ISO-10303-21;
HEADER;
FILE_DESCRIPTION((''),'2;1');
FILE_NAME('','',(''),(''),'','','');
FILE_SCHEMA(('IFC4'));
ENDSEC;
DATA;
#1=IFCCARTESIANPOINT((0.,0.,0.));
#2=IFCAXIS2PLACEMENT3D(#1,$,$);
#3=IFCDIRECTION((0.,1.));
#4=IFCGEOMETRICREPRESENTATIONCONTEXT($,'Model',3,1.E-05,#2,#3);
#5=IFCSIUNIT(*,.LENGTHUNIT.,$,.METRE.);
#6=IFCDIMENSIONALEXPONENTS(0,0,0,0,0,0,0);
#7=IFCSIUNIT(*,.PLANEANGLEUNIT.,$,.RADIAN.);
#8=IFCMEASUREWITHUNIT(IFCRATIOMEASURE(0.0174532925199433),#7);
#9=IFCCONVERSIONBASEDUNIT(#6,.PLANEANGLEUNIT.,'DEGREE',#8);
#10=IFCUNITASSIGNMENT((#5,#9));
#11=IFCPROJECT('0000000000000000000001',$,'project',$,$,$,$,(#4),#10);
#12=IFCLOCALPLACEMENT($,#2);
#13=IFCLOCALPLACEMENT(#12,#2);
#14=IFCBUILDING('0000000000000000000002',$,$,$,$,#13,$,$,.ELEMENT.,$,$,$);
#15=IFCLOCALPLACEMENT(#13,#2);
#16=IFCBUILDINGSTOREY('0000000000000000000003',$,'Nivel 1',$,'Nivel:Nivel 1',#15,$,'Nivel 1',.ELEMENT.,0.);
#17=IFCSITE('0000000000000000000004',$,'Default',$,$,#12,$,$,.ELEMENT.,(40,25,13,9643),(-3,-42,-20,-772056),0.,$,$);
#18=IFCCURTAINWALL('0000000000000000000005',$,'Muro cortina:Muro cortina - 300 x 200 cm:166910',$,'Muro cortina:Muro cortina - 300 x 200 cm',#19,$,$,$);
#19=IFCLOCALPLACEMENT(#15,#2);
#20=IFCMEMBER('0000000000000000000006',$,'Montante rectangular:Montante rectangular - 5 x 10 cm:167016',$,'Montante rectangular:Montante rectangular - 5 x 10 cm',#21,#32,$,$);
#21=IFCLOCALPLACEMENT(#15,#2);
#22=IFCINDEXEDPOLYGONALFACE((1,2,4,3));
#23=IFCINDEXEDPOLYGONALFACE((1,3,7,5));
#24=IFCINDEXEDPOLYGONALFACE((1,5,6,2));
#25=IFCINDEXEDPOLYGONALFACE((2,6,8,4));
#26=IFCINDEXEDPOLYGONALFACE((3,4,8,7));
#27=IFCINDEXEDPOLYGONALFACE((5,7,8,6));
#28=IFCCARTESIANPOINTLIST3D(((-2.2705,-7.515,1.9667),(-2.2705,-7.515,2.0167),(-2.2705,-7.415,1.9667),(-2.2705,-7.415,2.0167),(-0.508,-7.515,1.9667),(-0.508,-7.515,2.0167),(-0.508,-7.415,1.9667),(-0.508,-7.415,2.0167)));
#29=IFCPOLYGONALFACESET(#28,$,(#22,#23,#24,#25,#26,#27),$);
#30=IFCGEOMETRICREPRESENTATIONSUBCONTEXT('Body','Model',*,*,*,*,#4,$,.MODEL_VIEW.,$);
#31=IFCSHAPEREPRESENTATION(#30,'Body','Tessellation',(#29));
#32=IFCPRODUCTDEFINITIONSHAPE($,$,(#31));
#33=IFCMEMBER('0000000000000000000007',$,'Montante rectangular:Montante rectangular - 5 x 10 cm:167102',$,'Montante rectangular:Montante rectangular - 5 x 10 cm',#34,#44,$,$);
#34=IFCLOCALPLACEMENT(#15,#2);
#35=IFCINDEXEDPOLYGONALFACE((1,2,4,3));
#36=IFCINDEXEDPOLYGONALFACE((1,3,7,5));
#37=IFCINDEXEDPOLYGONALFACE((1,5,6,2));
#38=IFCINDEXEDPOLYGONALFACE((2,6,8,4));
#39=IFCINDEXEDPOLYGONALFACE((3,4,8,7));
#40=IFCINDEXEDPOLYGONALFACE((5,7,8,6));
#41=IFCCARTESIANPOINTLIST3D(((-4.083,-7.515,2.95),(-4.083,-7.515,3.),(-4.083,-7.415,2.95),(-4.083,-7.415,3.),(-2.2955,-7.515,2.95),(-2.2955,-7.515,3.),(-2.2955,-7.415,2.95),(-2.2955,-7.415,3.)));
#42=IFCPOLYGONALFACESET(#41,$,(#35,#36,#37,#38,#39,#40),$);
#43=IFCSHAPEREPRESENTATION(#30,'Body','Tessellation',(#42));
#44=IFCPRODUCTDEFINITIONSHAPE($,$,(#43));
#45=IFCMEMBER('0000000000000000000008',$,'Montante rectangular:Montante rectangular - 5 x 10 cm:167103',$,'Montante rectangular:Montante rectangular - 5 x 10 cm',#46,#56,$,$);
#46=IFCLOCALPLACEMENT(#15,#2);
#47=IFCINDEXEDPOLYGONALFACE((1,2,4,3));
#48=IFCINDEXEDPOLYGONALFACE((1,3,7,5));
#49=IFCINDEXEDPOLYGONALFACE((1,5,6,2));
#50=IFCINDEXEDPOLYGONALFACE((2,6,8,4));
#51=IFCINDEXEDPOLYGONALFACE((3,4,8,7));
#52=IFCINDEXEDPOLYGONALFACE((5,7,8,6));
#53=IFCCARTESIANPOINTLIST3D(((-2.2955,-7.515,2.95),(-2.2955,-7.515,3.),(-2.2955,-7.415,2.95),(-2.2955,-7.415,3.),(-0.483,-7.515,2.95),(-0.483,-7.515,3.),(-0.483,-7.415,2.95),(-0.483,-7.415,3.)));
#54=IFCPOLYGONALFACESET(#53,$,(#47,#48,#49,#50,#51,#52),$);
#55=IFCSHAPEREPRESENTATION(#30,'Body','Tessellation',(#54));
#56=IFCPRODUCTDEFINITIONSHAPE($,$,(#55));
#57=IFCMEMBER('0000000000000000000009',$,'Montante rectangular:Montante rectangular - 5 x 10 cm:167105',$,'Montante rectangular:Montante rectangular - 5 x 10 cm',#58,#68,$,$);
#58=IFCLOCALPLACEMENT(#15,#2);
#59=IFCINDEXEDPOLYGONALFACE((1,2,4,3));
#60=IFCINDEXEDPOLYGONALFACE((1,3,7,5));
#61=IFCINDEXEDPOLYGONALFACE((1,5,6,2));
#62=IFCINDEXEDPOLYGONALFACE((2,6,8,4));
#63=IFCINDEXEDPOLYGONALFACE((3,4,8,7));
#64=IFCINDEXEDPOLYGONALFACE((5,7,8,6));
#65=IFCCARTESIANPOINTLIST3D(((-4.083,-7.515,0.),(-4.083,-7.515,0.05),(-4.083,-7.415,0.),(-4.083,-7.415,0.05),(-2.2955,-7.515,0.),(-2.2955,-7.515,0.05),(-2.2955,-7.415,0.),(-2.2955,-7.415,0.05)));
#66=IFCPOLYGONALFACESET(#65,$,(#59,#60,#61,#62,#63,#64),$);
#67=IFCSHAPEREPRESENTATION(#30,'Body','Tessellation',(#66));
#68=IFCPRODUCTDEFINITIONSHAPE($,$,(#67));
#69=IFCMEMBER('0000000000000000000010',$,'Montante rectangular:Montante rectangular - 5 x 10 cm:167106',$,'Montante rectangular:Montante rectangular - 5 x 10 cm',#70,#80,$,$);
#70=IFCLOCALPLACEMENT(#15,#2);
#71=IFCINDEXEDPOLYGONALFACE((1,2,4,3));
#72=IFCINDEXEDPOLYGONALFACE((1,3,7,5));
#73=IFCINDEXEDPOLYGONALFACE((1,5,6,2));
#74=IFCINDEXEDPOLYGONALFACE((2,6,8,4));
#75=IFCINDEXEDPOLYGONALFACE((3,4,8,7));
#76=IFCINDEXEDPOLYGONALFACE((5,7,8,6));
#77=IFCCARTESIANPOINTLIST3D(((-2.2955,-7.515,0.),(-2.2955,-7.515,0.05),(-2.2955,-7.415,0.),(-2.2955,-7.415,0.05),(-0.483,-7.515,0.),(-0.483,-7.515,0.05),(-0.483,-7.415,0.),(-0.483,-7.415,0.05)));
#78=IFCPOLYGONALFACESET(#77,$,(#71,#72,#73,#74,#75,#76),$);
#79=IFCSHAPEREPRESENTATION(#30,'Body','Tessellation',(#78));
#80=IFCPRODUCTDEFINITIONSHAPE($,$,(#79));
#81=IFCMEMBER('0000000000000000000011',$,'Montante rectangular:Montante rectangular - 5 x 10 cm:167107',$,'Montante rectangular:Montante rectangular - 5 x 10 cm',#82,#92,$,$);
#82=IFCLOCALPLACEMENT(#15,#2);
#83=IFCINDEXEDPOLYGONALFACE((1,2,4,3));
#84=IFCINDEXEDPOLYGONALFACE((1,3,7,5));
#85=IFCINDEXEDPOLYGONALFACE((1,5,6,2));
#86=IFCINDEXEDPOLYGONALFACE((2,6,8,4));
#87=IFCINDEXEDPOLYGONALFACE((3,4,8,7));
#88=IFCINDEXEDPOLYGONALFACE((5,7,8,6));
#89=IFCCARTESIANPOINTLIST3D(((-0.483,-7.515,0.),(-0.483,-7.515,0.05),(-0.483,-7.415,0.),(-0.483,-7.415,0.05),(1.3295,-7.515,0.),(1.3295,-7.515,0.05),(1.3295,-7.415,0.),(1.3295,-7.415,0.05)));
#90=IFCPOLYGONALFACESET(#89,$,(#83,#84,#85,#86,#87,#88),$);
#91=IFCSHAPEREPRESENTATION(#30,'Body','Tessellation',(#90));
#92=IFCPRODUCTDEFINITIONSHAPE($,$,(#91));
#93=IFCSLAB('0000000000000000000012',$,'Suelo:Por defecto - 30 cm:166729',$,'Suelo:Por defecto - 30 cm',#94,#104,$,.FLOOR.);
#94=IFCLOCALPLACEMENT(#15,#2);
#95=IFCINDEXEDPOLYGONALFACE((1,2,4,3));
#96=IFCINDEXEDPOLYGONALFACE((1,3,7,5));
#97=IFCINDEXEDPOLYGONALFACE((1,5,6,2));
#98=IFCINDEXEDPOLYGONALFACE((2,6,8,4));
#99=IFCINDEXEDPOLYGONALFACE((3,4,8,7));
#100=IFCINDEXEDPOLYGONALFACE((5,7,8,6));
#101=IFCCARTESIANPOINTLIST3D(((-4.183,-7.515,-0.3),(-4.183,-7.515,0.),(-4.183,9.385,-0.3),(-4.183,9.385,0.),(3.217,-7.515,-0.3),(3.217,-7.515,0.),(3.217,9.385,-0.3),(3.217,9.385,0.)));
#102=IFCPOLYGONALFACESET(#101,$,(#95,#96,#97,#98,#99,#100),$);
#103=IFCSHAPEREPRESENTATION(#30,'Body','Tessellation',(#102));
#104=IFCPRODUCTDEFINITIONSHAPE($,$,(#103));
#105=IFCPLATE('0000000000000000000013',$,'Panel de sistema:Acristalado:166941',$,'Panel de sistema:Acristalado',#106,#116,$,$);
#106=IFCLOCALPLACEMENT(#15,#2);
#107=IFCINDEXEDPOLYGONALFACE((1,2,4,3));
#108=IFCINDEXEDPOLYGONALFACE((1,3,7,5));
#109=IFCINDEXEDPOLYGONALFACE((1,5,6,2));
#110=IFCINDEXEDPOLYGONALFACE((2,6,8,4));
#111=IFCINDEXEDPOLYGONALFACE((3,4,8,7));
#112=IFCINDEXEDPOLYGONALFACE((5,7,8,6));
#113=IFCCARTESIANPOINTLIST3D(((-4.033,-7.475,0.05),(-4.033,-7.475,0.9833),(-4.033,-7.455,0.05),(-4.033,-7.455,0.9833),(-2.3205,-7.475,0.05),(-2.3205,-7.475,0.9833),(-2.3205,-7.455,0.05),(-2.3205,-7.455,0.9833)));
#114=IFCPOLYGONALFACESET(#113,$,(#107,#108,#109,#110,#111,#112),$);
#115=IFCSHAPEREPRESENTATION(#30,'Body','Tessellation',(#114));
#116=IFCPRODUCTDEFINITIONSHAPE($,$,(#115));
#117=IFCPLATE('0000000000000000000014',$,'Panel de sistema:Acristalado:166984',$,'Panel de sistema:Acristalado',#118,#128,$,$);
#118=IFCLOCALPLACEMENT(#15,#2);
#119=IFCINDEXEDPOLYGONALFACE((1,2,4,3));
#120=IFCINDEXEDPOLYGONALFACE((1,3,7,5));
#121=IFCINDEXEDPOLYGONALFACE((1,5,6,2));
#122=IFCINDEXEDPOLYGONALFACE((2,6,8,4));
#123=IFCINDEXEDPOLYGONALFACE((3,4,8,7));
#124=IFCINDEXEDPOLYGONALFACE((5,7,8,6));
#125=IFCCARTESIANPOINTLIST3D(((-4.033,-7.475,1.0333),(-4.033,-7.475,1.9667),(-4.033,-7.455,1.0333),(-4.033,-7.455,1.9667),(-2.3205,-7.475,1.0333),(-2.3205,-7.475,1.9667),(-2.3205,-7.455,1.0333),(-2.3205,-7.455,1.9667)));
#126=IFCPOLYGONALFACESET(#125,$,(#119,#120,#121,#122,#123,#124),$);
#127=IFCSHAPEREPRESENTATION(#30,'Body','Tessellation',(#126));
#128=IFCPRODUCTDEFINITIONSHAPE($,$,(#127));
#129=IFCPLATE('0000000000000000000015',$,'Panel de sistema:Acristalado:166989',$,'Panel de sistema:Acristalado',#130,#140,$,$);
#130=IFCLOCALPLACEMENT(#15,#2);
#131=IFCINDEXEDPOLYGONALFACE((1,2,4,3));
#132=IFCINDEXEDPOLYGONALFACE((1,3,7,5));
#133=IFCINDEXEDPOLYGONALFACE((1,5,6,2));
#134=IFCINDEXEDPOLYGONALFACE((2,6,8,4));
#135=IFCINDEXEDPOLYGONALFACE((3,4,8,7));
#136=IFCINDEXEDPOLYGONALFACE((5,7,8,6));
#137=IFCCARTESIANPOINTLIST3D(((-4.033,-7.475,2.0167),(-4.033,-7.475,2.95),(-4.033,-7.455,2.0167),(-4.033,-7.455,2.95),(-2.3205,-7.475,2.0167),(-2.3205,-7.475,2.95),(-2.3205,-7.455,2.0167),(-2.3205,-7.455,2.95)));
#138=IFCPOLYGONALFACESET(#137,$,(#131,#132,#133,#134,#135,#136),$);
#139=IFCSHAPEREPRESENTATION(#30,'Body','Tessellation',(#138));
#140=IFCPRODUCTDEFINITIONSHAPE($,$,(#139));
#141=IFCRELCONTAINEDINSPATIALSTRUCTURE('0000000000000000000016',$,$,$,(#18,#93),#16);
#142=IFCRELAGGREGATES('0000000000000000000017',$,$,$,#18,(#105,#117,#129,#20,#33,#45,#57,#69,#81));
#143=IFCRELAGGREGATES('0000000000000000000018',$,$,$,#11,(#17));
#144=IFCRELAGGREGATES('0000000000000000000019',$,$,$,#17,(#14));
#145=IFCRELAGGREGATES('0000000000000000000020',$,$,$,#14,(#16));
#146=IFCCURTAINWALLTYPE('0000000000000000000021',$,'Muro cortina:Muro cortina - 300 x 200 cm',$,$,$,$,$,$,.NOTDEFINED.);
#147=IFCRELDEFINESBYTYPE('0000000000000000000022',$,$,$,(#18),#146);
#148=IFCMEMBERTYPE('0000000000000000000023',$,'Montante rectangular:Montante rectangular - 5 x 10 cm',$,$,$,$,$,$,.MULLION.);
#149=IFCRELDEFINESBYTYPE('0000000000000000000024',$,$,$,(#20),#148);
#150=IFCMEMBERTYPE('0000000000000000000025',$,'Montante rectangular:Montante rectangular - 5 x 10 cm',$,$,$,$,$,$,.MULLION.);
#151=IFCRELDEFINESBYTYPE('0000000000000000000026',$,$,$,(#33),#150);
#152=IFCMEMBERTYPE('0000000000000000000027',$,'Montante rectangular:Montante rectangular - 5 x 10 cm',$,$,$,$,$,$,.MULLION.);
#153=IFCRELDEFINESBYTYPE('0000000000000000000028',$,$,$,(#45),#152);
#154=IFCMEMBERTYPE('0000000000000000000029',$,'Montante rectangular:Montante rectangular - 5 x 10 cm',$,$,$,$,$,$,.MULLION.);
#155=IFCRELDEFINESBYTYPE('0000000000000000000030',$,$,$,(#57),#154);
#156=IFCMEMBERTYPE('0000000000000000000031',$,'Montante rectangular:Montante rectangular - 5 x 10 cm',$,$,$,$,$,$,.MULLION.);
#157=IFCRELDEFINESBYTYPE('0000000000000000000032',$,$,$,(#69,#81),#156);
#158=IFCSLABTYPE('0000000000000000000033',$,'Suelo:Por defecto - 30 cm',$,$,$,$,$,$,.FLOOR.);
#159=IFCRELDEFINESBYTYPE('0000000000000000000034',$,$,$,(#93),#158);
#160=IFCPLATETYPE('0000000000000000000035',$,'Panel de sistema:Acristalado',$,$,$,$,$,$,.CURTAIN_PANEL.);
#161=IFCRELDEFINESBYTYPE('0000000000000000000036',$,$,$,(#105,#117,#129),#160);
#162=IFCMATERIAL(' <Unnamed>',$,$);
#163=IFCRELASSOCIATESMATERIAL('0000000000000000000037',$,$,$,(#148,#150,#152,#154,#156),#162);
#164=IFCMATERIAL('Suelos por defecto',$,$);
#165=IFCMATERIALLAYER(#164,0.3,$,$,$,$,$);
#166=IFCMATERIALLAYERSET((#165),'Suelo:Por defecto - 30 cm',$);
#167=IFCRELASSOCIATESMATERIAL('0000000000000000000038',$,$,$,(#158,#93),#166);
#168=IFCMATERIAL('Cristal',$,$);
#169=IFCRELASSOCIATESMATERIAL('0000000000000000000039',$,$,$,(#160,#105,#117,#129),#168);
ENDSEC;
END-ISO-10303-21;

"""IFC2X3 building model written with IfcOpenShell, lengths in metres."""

from ifc_helpers import new_model, entity, si_unit, converted_unit, direction, frame, origin, origin_2d_with_axis, place, context, subcontext, project, spatial, rectangle, extrude, source, transform, mapped, material, layer, layer_set, layer_usage, type_object, type_shapes, element, aggregate, save


model = new_model("IFC2X3")

# Units and contexts
model_context = context("Model", 3, precision=1e-05, world=origin(), true_north=direction((0.0, 1.0)))
body_context = subcontext(model_context, "Body", "Model", "MODEL_VIEW")
ifc_project = project(units=[si_unit("LENGTHUNIT", "METRE"), converted_unit("PLANEANGLEUNIT", "DEGREE", entity("IfcRatioMeasure", 0.0174532925199433), si_unit("PLANEANGLEUNIT", "RADIAN"), dimensions=[0, 0, 0, 0, 0, 0, 0])], contexts=[model_context])

# Site, building, storey
site_placement = place(None, origin())
site = spatial("IfcSite", under=ifc_project, at=site_placement, Name="Default", CompositionType="ELEMENT", RefLatitude=(40, 25, 13, 9643), RefLongitude=(-3, -42, -20, -772056), RefElevation=0.0)
building_placement = place(site_placement, origin())
building = spatial("IfcBuilding", under=site, at=building_placement, CompositionType="ELEMENT")
storey_placement = place(building_placement, origin())
storey = spatial("IfcBuildingStorey", under=building, at=storey_placement, Name="Nivel 1", ObjectType="Nivel:Nivel 1", LongName="Nivel 1", CompositionType="ELEMENT", Elevation=0.0)

# Curtain wall, members
curtain_wall_type = type_object("IfcCurtainWallType", Name="Muro cortina:Muro cortina - 300 x 200 cm", PredefinedType="NOTDEFINED")
curtain_wall_placement = place(storey_placement, origin())
curtain_wall = element("IfcCurtainWall", 1, at=curtain_wall_placement, inside=storey, type_object=curtain_wall_type, Name="Muro cortina:Muro cortina - 300 x 200 cm:166910", ObjectType="Muro cortina:Muro cortina - 300 x 200 cm")
ifc_material_1 = material(Name=" <Unnamed>")
member_type_1 = type_object("IfcMemberType", Name="Montante rectangular:Montante rectangular - 5 x 10 cm", PredefinedType="MULLION", material=ifc_material_1)
shared_shape_1 = source(origin(), body_context, "Body", "SweptSolid", [
    extrude(rectangle(XDim=0.1, YDim=0.05, at=origin_2d_with_axis()), frame((0.0, 0.0, -1.7625), z_axis=(0.0, 0.0, 1.0), x_axis=(0.0, -1.0, 0.0)), (0.0, 0.0, 1.0), 1.7625),
])
type_shapes(member_type_1, [shared_shape_1])
member_1_placement = place(storey_placement, frame((-0.508, -7.465, 1.9917), z_axis=(1.0, 0.0, 0.0), x_axis=(0.0, 0.0, 1.0)))
member_1 = element("IfcMember", 2, at=member_1_placement, type_object=member_type_1, Name="Montante rectangular:Montante rectangular - 5 x 10 cm:167016", ObjectType="Montante rectangular:Montante rectangular - 5 x 10 cm", context=body_context, shape_type="MappedRepresentation", body=[
    mapped(shared_shape_1, transform((0.0, 0.0, 0.0), scale=1.0)),
])
member_type_2 = type_object("IfcMemberType", Name="Montante rectangular:Montante rectangular - 5 x 10 cm", PredefinedType="MULLION", material=ifc_material_1)
shared_shape_2 = source(origin(), body_context, "Body", "SweptSolid", [
    extrude(rectangle(XDim=0.1, YDim=0.05, at=origin_2d_with_axis()), frame((-0.025, 0.0, -1.7875), z_axis=(0.0, 0.0, 1.0), x_axis=(0.0, -1.0, 0.0)), (0.0, 0.0, 1.0), 1.7875),
])
type_shapes(member_type_2, [shared_shape_2])
member_2_placement = place(storey_placement, frame((-2.2955, -7.465, 3.0), z_axis=(1.0, 0.0, 0.0), x_axis=(0.0, 0.0, 1.0)))
member_2 = element("IfcMember", 3, at=member_2_placement, type_object=member_type_2, Name="Montante rectangular:Montante rectangular - 5 x 10 cm:167102", ObjectType="Montante rectangular:Montante rectangular - 5 x 10 cm", context=body_context, shape_type="MappedRepresentation", body=[
    mapped(shared_shape_2, transform((0.0, 0.0, 0.0), scale=1.0)),
])
member_type_3 = type_object("IfcMemberType", Name="Montante rectangular:Montante rectangular - 5 x 10 cm", PredefinedType="MULLION", material=ifc_material_1)
shared_shape_3 = source(origin(), body_context, "Body", "SweptSolid", [
    extrude(rectangle(XDim=0.1, YDim=0.05, at=origin_2d_with_axis()), frame((-0.025, 0.0, -1.8125), z_axis=(0.0, 0.0, 1.0), x_axis=(0.0, -1.0, 0.0)), (0.0, 0.0, 1.0), 1.8125),
])
type_shapes(member_type_3, [shared_shape_3])
member_3_placement = place(storey_placement, frame((-0.483, -7.465, 3.0), z_axis=(1.0, 0.0, 0.0), x_axis=(0.0, 0.0, 1.0)))
member_3 = element("IfcMember", 4, at=member_3_placement, type_object=member_type_3, Name="Montante rectangular:Montante rectangular - 5 x 10 cm:167103", ObjectType="Montante rectangular:Montante rectangular - 5 x 10 cm", context=body_context, shape_type="MappedRepresentation", body=[
    mapped(shared_shape_3, transform((0.0, 0.0, 0.0), scale=1.0)),
])
member_type_4 = type_object("IfcMemberType", Name="Montante rectangular:Montante rectangular - 5 x 10 cm", PredefinedType="MULLION", material=ifc_material_1)
shared_shape_4 = source(origin(), body_context, "Body", "SweptSolid", [
    extrude(rectangle(XDim=0.1, YDim=0.05, at=origin_2d_with_axis()), frame((-0.025, 0.0, -1.7875), z_axis=(0.0, 0.0, 1.0), x_axis=(0.0, -1.0, 0.0)), (0.0, 0.0, 1.0), 1.7875),
])
type_shapes(member_type_4, [shared_shape_4])
member_4_placement = place(storey_placement, frame((-4.083, -7.465, 0.0), z_axis=(-1.0, 0.0, 0.0), x_axis=(0.0, 0.0, -1.0)))
member_4 = element("IfcMember", 5, at=member_4_placement, type_object=member_type_4, Name="Montante rectangular:Montante rectangular - 5 x 10 cm:167105", ObjectType="Montante rectangular:Montante rectangular - 5 x 10 cm", context=body_context, shape_type="MappedRepresentation", body=[
    mapped(shared_shape_4, transform((0.0, 0.0, 0.0), scale=1.0)),
])
member_type_5 = type_object("IfcMemberType", Name="Montante rectangular:Montante rectangular - 5 x 10 cm", PredefinedType="MULLION", material=ifc_material_1)
shared_shape_5 = source(origin(), body_context, "Body", "SweptSolid", [
    extrude(rectangle(XDim=0.1, YDim=0.05, at=origin_2d_with_axis()), frame((-0.025, 0.0, -1.8125), z_axis=(0.0, 0.0, 1.0), x_axis=(0.0, -1.0, 0.0)), (0.0, 0.0, 1.0), 1.8125),
])
type_shapes(member_type_5, [shared_shape_5])
member_5_placement = place(storey_placement, frame((-2.2955, -7.465, 0.0), z_axis=(-1.0, 0.0, 0.0), x_axis=(0.0, 0.0, -1.0)))
member_5 = element("IfcMember", 6, at=member_5_placement, type_object=member_type_5, Name="Montante rectangular:Montante rectangular - 5 x 10 cm:167106", ObjectType="Montante rectangular:Montante rectangular - 5 x 10 cm", context=body_context, shape_type="MappedRepresentation", body=[
    mapped(shared_shape_5, transform((0.0, 0.0, 0.0), scale=1.0)),
])
member_6_placement = place(storey_placement, frame((-0.483, -7.465, 0.0), z_axis=(-1.0, 0.0, 0.0), x_axis=(0.0, 0.0, -1.0)))
member_6 = element("IfcMember", 7, at=member_6_placement, type_object=member_type_5, Name="Montante rectangular:Montante rectangular - 5 x 10 cm:167107", ObjectType="Montante rectangular:Montante rectangular - 5 x 10 cm", context=body_context, shape_type="MappedRepresentation", body=[
    mapped(shared_shape_5, transform((0.0, 0.0, 0.0), scale=1.0)),
])

# Slab
ifc_material_2 = material(Name="Suelos por defecto")
ifc_layer_1 = layer(ifc_material_2, 0.3)
ifc_layer_set_1 = layer_set([ifc_layer_1], Name="Suelo:Por defecto - 30 cm")
ifc_layer_usage_1 = layer_usage(ifc_layer_set_1, "AXIS3", "POSITIVE", 0.0)
slab_type = type_object("IfcSlabType", Name="Suelo:Por defecto - 30 cm", PredefinedType="FLOOR", material=ifc_layer_set_1)
slab_placement = place(storey_placement, origin())
element("IfcSlab", 8, at=slab_placement, inside=storey, type_object=slab_type, material=ifc_layer_usage_1, Name="Suelo:Por defecto - 30 cm:166729", ObjectType="Suelo:Por defecto - 30 cm", PredefinedType="FLOOR", context=body_context, shape_type="SweptSolid", body=[
    extrude(rectangle(XDim=16.9, YDim=7.4, at=origin_2d_with_axis()), frame((-0.483, 0.935, 0.0), z_axis=(0.0, 0.0, -1.0), x_axis=(0.0, 1.0, 0.0)), (0.0, 0.0, 1.0), 0.3),
])

# Plates
ifc_material_3 = material(Name="Cristal")
plate_type = type_object("IfcPlateType", Name="Panel de sistema:Acristalado", PredefinedType="CURTAIN_PANEL", material=ifc_material_3)
shared_shape_6 = source(origin(), body_context, "Body", "SweptSolid", [
    extrude(rectangle(XDim=0.02, YDim=1.7125, at=origin_2d_with_axis()), frame((0.0, 0.0, 0.0), z_axis=(0.0, 0.0, 1.0), x_axis=(0.0, 1.0, 0.0)), (0.0, 0.0, 1.0), 0.9333),
])
type_shapes(plate_type, [shared_shape_6])
plate_1_placement = place(curtain_wall_placement, frame((-3.1768, -7.465, 0.05)))
plate_1 = element("IfcPlate", 9, at=plate_1_placement, type_object=plate_type, material=ifc_material_3, Name="Panel de sistema:Acristalado:166941", ObjectType="Panel de sistema:Acristalado", context=body_context, shape_type="MappedRepresentation", body=[
    mapped(shared_shape_6, transform((0.0, 0.0, 0.0), scale=1.0)),
])
plate_2_placement = place(curtain_wall_placement, frame((-3.1768, -7.465, 1.0333)))
plate_2 = element("IfcPlate", 10, at=plate_2_placement, type_object=plate_type, material=ifc_material_3, Name="Panel de sistema:Acristalado:166984", ObjectType="Panel de sistema:Acristalado", context=body_context, shape_type="MappedRepresentation", body=[
    mapped(shared_shape_6, transform((0.0, 0.0, 0.0), scale=1.0)),
])
plate_3_placement = place(curtain_wall_placement, frame((-3.1768, -7.465, 2.0167)))
plate_3 = element("IfcPlate", 11, at=plate_3_placement, type_object=plate_type, material=ifc_material_3, Name="Panel de sistema:Acristalado:166989", ObjectType="Panel de sistema:Acristalado", context=body_context, shape_type="MappedRepresentation", body=[
    mapped(shared_shape_6, transform((0.0, 0.0, 0.0), scale=1.0)),
])
aggregate(curtain_wall, [plate_1, plate_2, plate_3, member_1, member_2, member_3, member_4, member_5, member_6])

save(model, "model.ifc")
